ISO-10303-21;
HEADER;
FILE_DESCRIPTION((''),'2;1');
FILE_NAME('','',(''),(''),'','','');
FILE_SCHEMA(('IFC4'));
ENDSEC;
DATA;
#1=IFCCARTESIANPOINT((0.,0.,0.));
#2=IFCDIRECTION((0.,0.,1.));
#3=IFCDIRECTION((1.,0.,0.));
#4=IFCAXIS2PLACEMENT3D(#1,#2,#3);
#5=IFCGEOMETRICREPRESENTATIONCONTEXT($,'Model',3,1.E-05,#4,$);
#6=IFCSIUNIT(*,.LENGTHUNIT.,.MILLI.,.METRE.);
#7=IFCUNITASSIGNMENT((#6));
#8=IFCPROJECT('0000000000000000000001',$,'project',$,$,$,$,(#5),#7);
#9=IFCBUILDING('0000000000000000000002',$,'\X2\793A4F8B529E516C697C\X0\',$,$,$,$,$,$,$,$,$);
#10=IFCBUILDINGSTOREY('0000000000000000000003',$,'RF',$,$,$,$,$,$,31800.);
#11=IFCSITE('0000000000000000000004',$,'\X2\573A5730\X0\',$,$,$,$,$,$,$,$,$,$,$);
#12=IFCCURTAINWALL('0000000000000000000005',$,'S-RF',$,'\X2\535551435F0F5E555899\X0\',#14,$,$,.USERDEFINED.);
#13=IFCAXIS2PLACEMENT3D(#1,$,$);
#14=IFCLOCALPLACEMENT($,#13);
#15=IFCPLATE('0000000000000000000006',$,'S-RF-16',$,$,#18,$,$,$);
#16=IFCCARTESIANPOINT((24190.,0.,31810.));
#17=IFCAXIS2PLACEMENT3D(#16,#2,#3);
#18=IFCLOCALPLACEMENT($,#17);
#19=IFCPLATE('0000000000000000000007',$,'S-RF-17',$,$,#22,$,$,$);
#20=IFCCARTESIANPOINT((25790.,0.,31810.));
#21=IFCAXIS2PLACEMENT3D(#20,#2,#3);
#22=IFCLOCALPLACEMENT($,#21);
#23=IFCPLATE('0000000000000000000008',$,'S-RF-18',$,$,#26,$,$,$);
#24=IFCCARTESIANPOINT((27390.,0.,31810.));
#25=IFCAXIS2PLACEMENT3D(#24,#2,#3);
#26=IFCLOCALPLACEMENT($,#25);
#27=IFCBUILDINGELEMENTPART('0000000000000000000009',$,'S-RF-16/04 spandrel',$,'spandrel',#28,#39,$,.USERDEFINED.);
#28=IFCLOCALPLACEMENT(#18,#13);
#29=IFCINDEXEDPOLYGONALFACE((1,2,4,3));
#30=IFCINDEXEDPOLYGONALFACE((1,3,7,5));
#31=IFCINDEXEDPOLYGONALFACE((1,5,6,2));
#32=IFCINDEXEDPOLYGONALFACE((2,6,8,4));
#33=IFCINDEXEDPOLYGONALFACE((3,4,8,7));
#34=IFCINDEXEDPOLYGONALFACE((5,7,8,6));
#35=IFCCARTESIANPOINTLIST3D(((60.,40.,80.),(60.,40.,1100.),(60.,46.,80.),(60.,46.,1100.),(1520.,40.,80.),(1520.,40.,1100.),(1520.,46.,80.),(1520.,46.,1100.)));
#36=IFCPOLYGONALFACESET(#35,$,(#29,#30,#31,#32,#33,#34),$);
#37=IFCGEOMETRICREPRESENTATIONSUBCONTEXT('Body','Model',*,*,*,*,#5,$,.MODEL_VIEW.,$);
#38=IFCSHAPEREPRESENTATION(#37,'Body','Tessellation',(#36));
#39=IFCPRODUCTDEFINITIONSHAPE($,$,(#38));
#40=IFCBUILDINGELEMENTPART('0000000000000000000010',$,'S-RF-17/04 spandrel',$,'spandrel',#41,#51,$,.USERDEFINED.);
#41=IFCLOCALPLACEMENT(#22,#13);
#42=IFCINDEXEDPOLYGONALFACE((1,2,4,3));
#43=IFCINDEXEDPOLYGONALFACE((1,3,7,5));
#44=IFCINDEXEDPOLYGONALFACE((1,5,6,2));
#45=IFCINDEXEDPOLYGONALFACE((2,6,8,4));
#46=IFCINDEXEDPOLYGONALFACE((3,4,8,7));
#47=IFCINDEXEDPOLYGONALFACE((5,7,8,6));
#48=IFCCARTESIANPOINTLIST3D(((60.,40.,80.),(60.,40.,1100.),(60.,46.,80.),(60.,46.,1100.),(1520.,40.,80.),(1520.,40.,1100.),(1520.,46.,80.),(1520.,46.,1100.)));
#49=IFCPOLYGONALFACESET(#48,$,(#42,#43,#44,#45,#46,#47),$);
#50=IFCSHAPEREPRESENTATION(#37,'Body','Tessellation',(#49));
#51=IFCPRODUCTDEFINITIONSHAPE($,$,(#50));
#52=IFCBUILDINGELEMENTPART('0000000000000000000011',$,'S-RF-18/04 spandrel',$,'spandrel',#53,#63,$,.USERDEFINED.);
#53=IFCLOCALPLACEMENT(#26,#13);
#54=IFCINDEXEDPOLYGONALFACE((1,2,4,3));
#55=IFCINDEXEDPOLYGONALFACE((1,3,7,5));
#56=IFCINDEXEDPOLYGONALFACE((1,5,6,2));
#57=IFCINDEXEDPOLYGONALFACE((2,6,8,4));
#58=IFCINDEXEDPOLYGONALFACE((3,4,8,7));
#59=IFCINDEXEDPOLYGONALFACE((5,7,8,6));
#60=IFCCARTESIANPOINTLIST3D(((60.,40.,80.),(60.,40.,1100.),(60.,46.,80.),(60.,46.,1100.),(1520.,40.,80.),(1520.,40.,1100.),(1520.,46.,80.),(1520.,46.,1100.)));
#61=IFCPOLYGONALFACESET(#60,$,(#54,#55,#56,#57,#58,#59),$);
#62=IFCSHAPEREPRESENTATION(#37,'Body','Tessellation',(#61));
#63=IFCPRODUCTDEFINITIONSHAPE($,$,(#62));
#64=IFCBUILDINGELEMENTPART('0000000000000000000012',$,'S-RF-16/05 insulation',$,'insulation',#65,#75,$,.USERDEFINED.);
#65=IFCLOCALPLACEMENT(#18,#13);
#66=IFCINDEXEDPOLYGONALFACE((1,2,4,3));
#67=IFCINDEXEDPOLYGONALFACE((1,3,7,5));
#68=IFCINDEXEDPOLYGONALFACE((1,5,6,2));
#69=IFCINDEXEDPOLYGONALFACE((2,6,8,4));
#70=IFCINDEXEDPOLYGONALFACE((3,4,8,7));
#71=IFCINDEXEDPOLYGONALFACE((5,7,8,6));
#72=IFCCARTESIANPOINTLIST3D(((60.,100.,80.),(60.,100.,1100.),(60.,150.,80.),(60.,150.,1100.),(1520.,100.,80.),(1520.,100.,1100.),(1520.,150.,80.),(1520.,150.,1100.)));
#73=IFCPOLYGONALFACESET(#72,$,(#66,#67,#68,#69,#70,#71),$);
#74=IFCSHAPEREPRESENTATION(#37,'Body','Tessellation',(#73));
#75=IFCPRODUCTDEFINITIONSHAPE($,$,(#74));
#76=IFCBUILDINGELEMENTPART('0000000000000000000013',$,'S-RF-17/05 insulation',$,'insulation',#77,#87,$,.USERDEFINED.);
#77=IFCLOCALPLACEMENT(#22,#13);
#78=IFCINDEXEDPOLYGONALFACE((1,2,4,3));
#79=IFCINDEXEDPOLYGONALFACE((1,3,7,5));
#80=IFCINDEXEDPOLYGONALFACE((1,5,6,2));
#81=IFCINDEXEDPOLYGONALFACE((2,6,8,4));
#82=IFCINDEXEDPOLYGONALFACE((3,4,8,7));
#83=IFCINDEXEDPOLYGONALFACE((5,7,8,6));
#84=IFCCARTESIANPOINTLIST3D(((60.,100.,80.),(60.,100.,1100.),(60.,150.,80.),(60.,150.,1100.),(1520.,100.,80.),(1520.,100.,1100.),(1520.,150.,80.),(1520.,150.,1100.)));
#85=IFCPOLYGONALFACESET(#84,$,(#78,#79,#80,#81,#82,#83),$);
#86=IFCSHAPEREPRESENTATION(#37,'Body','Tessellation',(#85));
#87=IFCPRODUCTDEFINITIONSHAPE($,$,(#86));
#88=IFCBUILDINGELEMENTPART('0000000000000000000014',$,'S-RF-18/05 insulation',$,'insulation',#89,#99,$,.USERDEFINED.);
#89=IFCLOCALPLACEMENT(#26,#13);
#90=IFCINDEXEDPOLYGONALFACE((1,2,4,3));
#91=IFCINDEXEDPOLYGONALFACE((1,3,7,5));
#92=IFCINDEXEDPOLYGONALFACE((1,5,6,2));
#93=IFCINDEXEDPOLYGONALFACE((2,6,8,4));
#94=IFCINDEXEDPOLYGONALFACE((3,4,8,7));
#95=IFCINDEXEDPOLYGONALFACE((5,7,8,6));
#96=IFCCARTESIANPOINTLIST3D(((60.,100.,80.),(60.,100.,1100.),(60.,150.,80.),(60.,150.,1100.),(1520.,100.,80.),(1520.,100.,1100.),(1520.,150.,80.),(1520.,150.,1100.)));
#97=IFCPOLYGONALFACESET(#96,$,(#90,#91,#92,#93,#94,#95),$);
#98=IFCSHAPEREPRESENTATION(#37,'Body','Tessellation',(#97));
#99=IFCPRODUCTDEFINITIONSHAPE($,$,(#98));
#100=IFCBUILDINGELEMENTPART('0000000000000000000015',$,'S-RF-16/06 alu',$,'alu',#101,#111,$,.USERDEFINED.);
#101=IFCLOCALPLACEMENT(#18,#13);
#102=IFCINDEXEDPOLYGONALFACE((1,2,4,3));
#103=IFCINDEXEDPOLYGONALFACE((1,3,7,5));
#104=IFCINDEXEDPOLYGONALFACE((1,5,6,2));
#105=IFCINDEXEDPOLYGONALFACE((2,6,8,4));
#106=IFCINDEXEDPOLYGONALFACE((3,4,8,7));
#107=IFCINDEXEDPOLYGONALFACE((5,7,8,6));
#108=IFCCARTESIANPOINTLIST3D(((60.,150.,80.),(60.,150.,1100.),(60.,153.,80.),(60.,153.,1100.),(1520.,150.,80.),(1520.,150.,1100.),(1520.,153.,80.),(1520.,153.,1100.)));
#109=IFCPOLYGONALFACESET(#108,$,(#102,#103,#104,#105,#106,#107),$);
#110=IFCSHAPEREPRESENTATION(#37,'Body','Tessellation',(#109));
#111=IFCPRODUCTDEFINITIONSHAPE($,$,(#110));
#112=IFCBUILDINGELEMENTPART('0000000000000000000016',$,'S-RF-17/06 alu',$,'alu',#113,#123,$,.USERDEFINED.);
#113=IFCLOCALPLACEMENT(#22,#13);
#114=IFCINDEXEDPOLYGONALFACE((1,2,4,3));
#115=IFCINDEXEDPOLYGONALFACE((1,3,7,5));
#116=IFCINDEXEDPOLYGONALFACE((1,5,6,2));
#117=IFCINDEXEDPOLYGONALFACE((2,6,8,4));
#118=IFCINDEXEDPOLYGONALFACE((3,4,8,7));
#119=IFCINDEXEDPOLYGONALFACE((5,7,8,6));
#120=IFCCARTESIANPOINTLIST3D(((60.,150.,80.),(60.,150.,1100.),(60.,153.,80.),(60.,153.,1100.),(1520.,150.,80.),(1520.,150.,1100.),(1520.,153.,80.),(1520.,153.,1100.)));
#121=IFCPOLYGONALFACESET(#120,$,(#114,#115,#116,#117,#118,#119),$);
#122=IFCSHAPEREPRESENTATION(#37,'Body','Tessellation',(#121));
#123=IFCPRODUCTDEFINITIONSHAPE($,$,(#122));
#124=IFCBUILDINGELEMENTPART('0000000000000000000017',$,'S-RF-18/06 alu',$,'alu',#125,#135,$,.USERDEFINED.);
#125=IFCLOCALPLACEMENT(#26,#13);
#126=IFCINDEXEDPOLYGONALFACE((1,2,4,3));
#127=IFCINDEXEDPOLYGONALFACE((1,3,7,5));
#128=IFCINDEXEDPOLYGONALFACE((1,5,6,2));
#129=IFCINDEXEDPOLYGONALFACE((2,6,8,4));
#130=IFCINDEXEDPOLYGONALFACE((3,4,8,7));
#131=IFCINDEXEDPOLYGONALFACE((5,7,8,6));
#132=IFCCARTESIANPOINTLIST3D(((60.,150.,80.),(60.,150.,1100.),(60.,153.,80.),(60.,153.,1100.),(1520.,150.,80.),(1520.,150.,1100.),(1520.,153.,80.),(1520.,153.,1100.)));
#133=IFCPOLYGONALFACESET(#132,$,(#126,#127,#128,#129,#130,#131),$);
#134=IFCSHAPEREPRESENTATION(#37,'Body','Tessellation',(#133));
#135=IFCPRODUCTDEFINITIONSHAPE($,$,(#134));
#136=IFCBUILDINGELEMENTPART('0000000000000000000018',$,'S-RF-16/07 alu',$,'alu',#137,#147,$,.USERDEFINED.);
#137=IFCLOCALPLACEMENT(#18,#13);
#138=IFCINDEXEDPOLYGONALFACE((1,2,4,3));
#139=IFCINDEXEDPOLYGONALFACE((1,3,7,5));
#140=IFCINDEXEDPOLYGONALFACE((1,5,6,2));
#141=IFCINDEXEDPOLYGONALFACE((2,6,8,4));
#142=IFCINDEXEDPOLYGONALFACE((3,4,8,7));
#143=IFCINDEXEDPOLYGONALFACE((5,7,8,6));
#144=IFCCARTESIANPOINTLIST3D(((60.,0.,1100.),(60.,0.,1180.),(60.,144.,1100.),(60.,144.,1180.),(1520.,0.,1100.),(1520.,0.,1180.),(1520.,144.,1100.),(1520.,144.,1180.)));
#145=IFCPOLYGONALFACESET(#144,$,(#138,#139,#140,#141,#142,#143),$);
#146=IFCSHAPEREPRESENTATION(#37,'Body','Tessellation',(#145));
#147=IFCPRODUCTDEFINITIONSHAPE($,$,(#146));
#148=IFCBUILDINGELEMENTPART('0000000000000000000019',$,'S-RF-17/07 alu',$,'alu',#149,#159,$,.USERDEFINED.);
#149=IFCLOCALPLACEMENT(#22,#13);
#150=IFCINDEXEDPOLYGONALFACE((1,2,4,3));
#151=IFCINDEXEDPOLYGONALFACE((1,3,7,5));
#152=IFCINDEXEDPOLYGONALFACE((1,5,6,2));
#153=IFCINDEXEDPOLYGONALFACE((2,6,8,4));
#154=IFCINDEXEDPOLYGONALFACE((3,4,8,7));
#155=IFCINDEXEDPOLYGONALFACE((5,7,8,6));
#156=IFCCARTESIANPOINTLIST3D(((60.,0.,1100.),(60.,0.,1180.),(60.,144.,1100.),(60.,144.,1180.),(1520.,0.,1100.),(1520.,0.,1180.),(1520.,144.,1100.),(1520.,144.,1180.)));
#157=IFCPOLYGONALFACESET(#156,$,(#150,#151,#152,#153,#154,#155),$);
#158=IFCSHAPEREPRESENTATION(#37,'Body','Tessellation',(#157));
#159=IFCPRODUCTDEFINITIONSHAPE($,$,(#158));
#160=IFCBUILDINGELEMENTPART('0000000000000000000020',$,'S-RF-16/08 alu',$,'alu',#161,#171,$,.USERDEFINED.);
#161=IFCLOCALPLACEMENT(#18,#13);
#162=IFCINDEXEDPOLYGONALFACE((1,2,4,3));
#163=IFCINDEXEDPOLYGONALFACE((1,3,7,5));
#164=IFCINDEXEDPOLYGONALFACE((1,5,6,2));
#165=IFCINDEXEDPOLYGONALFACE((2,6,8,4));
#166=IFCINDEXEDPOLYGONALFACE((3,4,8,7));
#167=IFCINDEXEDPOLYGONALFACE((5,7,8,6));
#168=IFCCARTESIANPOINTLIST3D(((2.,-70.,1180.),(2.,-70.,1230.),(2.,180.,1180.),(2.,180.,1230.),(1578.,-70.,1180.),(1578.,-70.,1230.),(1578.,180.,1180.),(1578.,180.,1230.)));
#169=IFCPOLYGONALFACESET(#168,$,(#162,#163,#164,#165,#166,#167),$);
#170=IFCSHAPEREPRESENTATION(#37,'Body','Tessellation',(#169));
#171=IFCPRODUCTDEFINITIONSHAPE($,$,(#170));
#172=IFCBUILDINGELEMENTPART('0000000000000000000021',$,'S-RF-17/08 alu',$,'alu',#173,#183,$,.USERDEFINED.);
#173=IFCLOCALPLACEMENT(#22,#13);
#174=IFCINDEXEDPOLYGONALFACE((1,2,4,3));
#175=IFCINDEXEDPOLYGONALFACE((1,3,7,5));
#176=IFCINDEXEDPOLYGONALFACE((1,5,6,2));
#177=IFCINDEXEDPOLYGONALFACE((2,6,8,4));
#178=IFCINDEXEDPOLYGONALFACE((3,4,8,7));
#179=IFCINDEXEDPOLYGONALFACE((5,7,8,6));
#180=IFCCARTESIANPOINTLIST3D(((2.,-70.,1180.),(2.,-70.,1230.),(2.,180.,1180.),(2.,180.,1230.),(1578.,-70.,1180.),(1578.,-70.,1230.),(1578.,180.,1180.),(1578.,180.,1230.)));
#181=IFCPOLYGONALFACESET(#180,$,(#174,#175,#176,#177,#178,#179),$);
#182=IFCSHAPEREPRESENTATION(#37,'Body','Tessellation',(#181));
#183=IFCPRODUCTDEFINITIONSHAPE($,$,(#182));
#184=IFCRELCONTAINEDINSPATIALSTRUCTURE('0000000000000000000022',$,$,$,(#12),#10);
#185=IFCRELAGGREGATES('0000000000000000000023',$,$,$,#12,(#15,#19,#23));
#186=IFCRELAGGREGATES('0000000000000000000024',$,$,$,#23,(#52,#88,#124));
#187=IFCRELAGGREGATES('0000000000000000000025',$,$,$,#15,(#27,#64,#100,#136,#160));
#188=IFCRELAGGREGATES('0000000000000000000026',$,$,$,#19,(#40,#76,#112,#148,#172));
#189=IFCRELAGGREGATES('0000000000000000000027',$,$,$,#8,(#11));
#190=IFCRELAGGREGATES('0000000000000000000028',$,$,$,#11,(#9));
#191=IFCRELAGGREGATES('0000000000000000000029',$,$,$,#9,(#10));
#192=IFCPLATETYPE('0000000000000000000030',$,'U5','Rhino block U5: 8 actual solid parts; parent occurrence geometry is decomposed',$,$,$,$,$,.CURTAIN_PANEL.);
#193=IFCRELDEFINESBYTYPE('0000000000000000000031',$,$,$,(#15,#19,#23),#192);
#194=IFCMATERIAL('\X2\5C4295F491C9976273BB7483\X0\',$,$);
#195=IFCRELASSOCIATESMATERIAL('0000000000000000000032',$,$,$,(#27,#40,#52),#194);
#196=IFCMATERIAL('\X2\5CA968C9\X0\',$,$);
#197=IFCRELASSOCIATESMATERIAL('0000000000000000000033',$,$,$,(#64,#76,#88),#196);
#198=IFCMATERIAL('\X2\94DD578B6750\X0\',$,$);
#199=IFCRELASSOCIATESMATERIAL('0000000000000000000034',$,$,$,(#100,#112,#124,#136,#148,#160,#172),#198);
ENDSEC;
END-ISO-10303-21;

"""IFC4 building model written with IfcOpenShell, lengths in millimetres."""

from ifc_helpers import new_model, si_unit, frame, frame_2d, origin, origin_with_axes, place, context, subcontext, project, spatial, rectangle, extrude, source, transform, mapped, material, type_object, element, aggregate, save


model = new_model("IFC4")

# Units and contexts
model_context = context("Model", 3, precision=1e-05, world=origin_with_axes())
body_context = subcontext(model_context, "Body", "Model", "MODEL_VIEW")
ifc_project = project(units=[si_unit("LENGTHUNIT", "METRE", prefix="MILLI")], contexts=[model_context])

# Site, building, storey
site = spatial("IfcSite", under=ifc_project, Name="场地")
building = spatial("IfcBuilding", under=site, Name="示例办公楼")
storey = spatial("IfcBuildingStorey", under=building, Name="RF", Elevation=31800.0)

# Curtain wall, plates, building element parts
curtain_wall = element("IfcCurtainWall", 1, inside=storey, Name="S-RF", ObjectType="单元式幕墙", PredefinedType="USERDEFINED")
plate_type = type_object("IfcPlateType", Name="U5", Description="Rhino block U5: 8 actual solid parts; parent occurrence geometry is decomposed", PredefinedType="CURTAIN_PANEL")
plate_1_placement = place(None, frame((24190.0, 0.0, 31810.0), z_axis=(0.0, 0.0, 1.0), x_axis=(1.0, 0.0, 0.0)))
plate_1 = element("IfcPlate", 2, at=plate_1_placement, type_object=plate_type, Name="S-RF-16")
ifc_material_1 = material(Name="铝型材")
plate_2_placement = place(None, frame((25790.0, 0.0, 31810.0), z_axis=(0.0, 0.0, 1.0), x_axis=(1.0, 0.0, 0.0)))
plate_2 = element("IfcPlate", 3, at=plate_2_placement, type_object=plate_type, Name="S-RF-17")
plate_3_placement = place(None, frame((27390.0, 0.0, 31810.0), z_axis=(0.0, 0.0, 1.0), x_axis=(1.0, 0.0, 0.0)))
plate_3 = element("IfcPlate", 4, at=plate_3_placement, type_object=plate_type, Name="S-RF-18")
aggregate(curtain_wall, [plate_1, plate_2, plate_3])
ifc_material_2 = material(Name="层间釉面玻璃")
shared_shape_1 = source(origin(), body_context, "Body", "SweptSolid", [
    extrude(rectangle(XDim=1460.0, YDim=6.0, at=frame_2d((790.0, 43.0))), frame((0.0, 0.0, 80.0)), (0.0, 0.0, 1.0), 1020.0),
])
building_element_part_1_placement = place(plate_1_placement, origin())
building_element_part_1 = element("IfcBuildingElementPart", 5, at=building_element_part_1_placement, material=ifc_material_2, Name="S-RF-16/04 spandrel", ObjectType="spandrel", PredefinedType="USERDEFINED", context=body_context, shape_type="MappedRepresentation", body=[
    mapped(shared_shape_1, transform((0.0, 0.0, 0.0))),
])
building_element_part_2_placement = place(plate_2_placement, origin())
building_element_part_2 = element("IfcBuildingElementPart", 6, at=building_element_part_2_placement, material=ifc_material_2, Name="S-RF-17/04 spandrel", ObjectType="spandrel", PredefinedType="USERDEFINED", context=body_context, shape_type="MappedRepresentation", body=[
    mapped(shared_shape_1, transform((0.0, 0.0, 0.0))),
])
building_element_part_3_placement = place(plate_3_placement, origin())
building_element_part_3 = element("IfcBuildingElementPart", 7, at=building_element_part_3_placement, material=ifc_material_2, Name="S-RF-18/04 spandrel", ObjectType="spandrel", PredefinedType="USERDEFINED", context=body_context, shape_type="MappedRepresentation", body=[
    mapped(shared_shape_1, transform((0.0, 0.0, 0.0))),
])
ifc_material_3 = material(Name="岩棉")
shared_shape_2 = source(origin(), body_context, "Body", "SweptSolid", [
    extrude(rectangle(XDim=1460.0, YDim=50.0, at=frame_2d((790.0, 125.0))), frame((0.0, 0.0, 80.0)), (0.0, 0.0, 1.0), 1020.0),
])
building_element_part_4_placement = place(plate_1_placement, origin())
building_element_part_4 = element("IfcBuildingElementPart", 8, at=building_element_part_4_placement, material=ifc_material_3, Name="S-RF-16/05 insulation", ObjectType="insulation", PredefinedType="USERDEFINED", context=body_context, shape_type="MappedRepresentation", body=[
    mapped(shared_shape_2, transform((0.0, 0.0, 0.0))),
])
building_element_part_5_placement = place(plate_2_placement, origin())
building_element_part_5 = element("IfcBuildingElementPart", 9, at=building_element_part_5_placement, material=ifc_material_3, Name="S-RF-17/05 insulation", ObjectType="insulation", PredefinedType="USERDEFINED", context=body_context, shape_type="MappedRepresentation", body=[
    mapped(shared_shape_2, transform((0.0, 0.0, 0.0))),
])
building_element_part_6_placement = place(plate_3_placement, origin())
building_element_part_6 = element("IfcBuildingElementPart", 10, at=building_element_part_6_placement, material=ifc_material_3, Name="S-RF-18/05 insulation", ObjectType="insulation", PredefinedType="USERDEFINED", context=body_context, shape_type="MappedRepresentation", body=[
    mapped(shared_shape_2, transform((0.0, 0.0, 0.0))),
])
shared_shape_3 = source(origin(), body_context, "Body", "SweptSolid", [
    extrude(rectangle(XDim=1460.0, YDim=3.0, at=frame_2d((790.0, 151.5))), frame((0.0, 0.0, 80.0)), (0.0, 0.0, 1.0), 1020.0),
])
building_element_part_7_placement = place(plate_1_placement, origin())
building_element_part_7 = element("IfcBuildingElementPart", 11, at=building_element_part_7_placement, material=ifc_material_1, Name="S-RF-16/06 alu", ObjectType="alu", PredefinedType="USERDEFINED", context=body_context, shape_type="MappedRepresentation", body=[
    mapped(shared_shape_3, transform((0.0, 0.0, 0.0))),
])
building_element_part_8_placement = place(plate_2_placement, origin())
building_element_part_8 = element("IfcBuildingElementPart", 12, at=building_element_part_8_placement, material=ifc_material_1, Name="S-RF-17/06 alu", ObjectType="alu", PredefinedType="USERDEFINED", context=body_context, shape_type="MappedRepresentation", body=[
    mapped(shared_shape_3, transform((0.0, 0.0, 0.0))),
])
building_element_part_9_placement = place(plate_3_placement, origin())
building_element_part_9 = element("IfcBuildingElementPart", 13, at=building_element_part_9_placement, material=ifc_material_1, Name="S-RF-18/06 alu", ObjectType="alu", PredefinedType="USERDEFINED", context=body_context, shape_type="MappedRepresentation", body=[
    mapped(shared_shape_3, transform((0.0, 0.0, 0.0))),
])
aggregate(plate_3, [building_element_part_3, building_element_part_6, building_element_part_9])
shared_shape_4 = source(origin(), body_context, "Body", "SweptSolid", [
    extrude(rectangle(XDim=1460.0, YDim=144.0, at=frame_2d((790.0, 72.0))), frame((0.0, 0.0, 1100.0)), (0.0, 0.0, 1.0), 80.0),
])
building_element_part_10_placement = place(plate_1_placement, origin())
building_element_part_10 = element("IfcBuildingElementPart", 14, at=building_element_part_10_placement, material=ifc_material_1, Name="S-RF-16/07 alu", ObjectType="alu", PredefinedType="USERDEFINED", context=body_context, shape_type="MappedRepresentation", body=[
    mapped(shared_shape_4, transform((0.0, 0.0, 0.0))),
])
building_element_part_11_placement = place(plate_2_placement, origin())
building_element_part_11 = element("IfcBuildingElementPart", 15, at=building_element_part_11_placement, material=ifc_material_1, Name="S-RF-17/07 alu", ObjectType="alu", PredefinedType="USERDEFINED", context=body_context, shape_type="MappedRepresentation", body=[
    mapped(shared_shape_4, transform((0.0, 0.0, 0.0))),
])
shared_shape_5 = source(origin(), body_context, "Body", "SweptSolid", [
    extrude(rectangle(XDim=1576.0, YDim=250.0, at=frame_2d((790.0, 55.0))), frame((0.0, 0.0, 1180.0)), (0.0, 0.0, 1.0), 50.0),
])
building_element_part_12_placement = place(plate_1_placement, origin())
building_element_part_12 = element("IfcBuildingElementPart", 16, at=building_element_part_12_placement, material=ifc_material_1, Name="S-RF-16/08 alu", ObjectType="alu", PredefinedType="USERDEFINED", context=body_context, shape_type="MappedRepresentation", body=[
    mapped(shared_shape_5, transform((0.0, 0.0, 0.0))),
])
aggregate(plate_1, [building_element_part_1, building_element_part_4, building_element_part_7, building_element_part_10, building_element_part_12])
building_element_part_13_placement = place(plate_2_placement, origin())
building_element_part_13 = element("IfcBuildingElementPart", 17, at=building_element_part_13_placement, material=ifc_material_1, Name="S-RF-17/08 alu", ObjectType="alu", PredefinedType="USERDEFINED", context=body_context, shape_type="MappedRepresentation", body=[
    mapped(shared_shape_5, transform((0.0, 0.0, 0.0))),
])
aggregate(plate_2, [building_element_part_2, building_element_part_5, building_element_part_8, building_element_part_11, building_element_part_13])

save(model, "model.ifc")
